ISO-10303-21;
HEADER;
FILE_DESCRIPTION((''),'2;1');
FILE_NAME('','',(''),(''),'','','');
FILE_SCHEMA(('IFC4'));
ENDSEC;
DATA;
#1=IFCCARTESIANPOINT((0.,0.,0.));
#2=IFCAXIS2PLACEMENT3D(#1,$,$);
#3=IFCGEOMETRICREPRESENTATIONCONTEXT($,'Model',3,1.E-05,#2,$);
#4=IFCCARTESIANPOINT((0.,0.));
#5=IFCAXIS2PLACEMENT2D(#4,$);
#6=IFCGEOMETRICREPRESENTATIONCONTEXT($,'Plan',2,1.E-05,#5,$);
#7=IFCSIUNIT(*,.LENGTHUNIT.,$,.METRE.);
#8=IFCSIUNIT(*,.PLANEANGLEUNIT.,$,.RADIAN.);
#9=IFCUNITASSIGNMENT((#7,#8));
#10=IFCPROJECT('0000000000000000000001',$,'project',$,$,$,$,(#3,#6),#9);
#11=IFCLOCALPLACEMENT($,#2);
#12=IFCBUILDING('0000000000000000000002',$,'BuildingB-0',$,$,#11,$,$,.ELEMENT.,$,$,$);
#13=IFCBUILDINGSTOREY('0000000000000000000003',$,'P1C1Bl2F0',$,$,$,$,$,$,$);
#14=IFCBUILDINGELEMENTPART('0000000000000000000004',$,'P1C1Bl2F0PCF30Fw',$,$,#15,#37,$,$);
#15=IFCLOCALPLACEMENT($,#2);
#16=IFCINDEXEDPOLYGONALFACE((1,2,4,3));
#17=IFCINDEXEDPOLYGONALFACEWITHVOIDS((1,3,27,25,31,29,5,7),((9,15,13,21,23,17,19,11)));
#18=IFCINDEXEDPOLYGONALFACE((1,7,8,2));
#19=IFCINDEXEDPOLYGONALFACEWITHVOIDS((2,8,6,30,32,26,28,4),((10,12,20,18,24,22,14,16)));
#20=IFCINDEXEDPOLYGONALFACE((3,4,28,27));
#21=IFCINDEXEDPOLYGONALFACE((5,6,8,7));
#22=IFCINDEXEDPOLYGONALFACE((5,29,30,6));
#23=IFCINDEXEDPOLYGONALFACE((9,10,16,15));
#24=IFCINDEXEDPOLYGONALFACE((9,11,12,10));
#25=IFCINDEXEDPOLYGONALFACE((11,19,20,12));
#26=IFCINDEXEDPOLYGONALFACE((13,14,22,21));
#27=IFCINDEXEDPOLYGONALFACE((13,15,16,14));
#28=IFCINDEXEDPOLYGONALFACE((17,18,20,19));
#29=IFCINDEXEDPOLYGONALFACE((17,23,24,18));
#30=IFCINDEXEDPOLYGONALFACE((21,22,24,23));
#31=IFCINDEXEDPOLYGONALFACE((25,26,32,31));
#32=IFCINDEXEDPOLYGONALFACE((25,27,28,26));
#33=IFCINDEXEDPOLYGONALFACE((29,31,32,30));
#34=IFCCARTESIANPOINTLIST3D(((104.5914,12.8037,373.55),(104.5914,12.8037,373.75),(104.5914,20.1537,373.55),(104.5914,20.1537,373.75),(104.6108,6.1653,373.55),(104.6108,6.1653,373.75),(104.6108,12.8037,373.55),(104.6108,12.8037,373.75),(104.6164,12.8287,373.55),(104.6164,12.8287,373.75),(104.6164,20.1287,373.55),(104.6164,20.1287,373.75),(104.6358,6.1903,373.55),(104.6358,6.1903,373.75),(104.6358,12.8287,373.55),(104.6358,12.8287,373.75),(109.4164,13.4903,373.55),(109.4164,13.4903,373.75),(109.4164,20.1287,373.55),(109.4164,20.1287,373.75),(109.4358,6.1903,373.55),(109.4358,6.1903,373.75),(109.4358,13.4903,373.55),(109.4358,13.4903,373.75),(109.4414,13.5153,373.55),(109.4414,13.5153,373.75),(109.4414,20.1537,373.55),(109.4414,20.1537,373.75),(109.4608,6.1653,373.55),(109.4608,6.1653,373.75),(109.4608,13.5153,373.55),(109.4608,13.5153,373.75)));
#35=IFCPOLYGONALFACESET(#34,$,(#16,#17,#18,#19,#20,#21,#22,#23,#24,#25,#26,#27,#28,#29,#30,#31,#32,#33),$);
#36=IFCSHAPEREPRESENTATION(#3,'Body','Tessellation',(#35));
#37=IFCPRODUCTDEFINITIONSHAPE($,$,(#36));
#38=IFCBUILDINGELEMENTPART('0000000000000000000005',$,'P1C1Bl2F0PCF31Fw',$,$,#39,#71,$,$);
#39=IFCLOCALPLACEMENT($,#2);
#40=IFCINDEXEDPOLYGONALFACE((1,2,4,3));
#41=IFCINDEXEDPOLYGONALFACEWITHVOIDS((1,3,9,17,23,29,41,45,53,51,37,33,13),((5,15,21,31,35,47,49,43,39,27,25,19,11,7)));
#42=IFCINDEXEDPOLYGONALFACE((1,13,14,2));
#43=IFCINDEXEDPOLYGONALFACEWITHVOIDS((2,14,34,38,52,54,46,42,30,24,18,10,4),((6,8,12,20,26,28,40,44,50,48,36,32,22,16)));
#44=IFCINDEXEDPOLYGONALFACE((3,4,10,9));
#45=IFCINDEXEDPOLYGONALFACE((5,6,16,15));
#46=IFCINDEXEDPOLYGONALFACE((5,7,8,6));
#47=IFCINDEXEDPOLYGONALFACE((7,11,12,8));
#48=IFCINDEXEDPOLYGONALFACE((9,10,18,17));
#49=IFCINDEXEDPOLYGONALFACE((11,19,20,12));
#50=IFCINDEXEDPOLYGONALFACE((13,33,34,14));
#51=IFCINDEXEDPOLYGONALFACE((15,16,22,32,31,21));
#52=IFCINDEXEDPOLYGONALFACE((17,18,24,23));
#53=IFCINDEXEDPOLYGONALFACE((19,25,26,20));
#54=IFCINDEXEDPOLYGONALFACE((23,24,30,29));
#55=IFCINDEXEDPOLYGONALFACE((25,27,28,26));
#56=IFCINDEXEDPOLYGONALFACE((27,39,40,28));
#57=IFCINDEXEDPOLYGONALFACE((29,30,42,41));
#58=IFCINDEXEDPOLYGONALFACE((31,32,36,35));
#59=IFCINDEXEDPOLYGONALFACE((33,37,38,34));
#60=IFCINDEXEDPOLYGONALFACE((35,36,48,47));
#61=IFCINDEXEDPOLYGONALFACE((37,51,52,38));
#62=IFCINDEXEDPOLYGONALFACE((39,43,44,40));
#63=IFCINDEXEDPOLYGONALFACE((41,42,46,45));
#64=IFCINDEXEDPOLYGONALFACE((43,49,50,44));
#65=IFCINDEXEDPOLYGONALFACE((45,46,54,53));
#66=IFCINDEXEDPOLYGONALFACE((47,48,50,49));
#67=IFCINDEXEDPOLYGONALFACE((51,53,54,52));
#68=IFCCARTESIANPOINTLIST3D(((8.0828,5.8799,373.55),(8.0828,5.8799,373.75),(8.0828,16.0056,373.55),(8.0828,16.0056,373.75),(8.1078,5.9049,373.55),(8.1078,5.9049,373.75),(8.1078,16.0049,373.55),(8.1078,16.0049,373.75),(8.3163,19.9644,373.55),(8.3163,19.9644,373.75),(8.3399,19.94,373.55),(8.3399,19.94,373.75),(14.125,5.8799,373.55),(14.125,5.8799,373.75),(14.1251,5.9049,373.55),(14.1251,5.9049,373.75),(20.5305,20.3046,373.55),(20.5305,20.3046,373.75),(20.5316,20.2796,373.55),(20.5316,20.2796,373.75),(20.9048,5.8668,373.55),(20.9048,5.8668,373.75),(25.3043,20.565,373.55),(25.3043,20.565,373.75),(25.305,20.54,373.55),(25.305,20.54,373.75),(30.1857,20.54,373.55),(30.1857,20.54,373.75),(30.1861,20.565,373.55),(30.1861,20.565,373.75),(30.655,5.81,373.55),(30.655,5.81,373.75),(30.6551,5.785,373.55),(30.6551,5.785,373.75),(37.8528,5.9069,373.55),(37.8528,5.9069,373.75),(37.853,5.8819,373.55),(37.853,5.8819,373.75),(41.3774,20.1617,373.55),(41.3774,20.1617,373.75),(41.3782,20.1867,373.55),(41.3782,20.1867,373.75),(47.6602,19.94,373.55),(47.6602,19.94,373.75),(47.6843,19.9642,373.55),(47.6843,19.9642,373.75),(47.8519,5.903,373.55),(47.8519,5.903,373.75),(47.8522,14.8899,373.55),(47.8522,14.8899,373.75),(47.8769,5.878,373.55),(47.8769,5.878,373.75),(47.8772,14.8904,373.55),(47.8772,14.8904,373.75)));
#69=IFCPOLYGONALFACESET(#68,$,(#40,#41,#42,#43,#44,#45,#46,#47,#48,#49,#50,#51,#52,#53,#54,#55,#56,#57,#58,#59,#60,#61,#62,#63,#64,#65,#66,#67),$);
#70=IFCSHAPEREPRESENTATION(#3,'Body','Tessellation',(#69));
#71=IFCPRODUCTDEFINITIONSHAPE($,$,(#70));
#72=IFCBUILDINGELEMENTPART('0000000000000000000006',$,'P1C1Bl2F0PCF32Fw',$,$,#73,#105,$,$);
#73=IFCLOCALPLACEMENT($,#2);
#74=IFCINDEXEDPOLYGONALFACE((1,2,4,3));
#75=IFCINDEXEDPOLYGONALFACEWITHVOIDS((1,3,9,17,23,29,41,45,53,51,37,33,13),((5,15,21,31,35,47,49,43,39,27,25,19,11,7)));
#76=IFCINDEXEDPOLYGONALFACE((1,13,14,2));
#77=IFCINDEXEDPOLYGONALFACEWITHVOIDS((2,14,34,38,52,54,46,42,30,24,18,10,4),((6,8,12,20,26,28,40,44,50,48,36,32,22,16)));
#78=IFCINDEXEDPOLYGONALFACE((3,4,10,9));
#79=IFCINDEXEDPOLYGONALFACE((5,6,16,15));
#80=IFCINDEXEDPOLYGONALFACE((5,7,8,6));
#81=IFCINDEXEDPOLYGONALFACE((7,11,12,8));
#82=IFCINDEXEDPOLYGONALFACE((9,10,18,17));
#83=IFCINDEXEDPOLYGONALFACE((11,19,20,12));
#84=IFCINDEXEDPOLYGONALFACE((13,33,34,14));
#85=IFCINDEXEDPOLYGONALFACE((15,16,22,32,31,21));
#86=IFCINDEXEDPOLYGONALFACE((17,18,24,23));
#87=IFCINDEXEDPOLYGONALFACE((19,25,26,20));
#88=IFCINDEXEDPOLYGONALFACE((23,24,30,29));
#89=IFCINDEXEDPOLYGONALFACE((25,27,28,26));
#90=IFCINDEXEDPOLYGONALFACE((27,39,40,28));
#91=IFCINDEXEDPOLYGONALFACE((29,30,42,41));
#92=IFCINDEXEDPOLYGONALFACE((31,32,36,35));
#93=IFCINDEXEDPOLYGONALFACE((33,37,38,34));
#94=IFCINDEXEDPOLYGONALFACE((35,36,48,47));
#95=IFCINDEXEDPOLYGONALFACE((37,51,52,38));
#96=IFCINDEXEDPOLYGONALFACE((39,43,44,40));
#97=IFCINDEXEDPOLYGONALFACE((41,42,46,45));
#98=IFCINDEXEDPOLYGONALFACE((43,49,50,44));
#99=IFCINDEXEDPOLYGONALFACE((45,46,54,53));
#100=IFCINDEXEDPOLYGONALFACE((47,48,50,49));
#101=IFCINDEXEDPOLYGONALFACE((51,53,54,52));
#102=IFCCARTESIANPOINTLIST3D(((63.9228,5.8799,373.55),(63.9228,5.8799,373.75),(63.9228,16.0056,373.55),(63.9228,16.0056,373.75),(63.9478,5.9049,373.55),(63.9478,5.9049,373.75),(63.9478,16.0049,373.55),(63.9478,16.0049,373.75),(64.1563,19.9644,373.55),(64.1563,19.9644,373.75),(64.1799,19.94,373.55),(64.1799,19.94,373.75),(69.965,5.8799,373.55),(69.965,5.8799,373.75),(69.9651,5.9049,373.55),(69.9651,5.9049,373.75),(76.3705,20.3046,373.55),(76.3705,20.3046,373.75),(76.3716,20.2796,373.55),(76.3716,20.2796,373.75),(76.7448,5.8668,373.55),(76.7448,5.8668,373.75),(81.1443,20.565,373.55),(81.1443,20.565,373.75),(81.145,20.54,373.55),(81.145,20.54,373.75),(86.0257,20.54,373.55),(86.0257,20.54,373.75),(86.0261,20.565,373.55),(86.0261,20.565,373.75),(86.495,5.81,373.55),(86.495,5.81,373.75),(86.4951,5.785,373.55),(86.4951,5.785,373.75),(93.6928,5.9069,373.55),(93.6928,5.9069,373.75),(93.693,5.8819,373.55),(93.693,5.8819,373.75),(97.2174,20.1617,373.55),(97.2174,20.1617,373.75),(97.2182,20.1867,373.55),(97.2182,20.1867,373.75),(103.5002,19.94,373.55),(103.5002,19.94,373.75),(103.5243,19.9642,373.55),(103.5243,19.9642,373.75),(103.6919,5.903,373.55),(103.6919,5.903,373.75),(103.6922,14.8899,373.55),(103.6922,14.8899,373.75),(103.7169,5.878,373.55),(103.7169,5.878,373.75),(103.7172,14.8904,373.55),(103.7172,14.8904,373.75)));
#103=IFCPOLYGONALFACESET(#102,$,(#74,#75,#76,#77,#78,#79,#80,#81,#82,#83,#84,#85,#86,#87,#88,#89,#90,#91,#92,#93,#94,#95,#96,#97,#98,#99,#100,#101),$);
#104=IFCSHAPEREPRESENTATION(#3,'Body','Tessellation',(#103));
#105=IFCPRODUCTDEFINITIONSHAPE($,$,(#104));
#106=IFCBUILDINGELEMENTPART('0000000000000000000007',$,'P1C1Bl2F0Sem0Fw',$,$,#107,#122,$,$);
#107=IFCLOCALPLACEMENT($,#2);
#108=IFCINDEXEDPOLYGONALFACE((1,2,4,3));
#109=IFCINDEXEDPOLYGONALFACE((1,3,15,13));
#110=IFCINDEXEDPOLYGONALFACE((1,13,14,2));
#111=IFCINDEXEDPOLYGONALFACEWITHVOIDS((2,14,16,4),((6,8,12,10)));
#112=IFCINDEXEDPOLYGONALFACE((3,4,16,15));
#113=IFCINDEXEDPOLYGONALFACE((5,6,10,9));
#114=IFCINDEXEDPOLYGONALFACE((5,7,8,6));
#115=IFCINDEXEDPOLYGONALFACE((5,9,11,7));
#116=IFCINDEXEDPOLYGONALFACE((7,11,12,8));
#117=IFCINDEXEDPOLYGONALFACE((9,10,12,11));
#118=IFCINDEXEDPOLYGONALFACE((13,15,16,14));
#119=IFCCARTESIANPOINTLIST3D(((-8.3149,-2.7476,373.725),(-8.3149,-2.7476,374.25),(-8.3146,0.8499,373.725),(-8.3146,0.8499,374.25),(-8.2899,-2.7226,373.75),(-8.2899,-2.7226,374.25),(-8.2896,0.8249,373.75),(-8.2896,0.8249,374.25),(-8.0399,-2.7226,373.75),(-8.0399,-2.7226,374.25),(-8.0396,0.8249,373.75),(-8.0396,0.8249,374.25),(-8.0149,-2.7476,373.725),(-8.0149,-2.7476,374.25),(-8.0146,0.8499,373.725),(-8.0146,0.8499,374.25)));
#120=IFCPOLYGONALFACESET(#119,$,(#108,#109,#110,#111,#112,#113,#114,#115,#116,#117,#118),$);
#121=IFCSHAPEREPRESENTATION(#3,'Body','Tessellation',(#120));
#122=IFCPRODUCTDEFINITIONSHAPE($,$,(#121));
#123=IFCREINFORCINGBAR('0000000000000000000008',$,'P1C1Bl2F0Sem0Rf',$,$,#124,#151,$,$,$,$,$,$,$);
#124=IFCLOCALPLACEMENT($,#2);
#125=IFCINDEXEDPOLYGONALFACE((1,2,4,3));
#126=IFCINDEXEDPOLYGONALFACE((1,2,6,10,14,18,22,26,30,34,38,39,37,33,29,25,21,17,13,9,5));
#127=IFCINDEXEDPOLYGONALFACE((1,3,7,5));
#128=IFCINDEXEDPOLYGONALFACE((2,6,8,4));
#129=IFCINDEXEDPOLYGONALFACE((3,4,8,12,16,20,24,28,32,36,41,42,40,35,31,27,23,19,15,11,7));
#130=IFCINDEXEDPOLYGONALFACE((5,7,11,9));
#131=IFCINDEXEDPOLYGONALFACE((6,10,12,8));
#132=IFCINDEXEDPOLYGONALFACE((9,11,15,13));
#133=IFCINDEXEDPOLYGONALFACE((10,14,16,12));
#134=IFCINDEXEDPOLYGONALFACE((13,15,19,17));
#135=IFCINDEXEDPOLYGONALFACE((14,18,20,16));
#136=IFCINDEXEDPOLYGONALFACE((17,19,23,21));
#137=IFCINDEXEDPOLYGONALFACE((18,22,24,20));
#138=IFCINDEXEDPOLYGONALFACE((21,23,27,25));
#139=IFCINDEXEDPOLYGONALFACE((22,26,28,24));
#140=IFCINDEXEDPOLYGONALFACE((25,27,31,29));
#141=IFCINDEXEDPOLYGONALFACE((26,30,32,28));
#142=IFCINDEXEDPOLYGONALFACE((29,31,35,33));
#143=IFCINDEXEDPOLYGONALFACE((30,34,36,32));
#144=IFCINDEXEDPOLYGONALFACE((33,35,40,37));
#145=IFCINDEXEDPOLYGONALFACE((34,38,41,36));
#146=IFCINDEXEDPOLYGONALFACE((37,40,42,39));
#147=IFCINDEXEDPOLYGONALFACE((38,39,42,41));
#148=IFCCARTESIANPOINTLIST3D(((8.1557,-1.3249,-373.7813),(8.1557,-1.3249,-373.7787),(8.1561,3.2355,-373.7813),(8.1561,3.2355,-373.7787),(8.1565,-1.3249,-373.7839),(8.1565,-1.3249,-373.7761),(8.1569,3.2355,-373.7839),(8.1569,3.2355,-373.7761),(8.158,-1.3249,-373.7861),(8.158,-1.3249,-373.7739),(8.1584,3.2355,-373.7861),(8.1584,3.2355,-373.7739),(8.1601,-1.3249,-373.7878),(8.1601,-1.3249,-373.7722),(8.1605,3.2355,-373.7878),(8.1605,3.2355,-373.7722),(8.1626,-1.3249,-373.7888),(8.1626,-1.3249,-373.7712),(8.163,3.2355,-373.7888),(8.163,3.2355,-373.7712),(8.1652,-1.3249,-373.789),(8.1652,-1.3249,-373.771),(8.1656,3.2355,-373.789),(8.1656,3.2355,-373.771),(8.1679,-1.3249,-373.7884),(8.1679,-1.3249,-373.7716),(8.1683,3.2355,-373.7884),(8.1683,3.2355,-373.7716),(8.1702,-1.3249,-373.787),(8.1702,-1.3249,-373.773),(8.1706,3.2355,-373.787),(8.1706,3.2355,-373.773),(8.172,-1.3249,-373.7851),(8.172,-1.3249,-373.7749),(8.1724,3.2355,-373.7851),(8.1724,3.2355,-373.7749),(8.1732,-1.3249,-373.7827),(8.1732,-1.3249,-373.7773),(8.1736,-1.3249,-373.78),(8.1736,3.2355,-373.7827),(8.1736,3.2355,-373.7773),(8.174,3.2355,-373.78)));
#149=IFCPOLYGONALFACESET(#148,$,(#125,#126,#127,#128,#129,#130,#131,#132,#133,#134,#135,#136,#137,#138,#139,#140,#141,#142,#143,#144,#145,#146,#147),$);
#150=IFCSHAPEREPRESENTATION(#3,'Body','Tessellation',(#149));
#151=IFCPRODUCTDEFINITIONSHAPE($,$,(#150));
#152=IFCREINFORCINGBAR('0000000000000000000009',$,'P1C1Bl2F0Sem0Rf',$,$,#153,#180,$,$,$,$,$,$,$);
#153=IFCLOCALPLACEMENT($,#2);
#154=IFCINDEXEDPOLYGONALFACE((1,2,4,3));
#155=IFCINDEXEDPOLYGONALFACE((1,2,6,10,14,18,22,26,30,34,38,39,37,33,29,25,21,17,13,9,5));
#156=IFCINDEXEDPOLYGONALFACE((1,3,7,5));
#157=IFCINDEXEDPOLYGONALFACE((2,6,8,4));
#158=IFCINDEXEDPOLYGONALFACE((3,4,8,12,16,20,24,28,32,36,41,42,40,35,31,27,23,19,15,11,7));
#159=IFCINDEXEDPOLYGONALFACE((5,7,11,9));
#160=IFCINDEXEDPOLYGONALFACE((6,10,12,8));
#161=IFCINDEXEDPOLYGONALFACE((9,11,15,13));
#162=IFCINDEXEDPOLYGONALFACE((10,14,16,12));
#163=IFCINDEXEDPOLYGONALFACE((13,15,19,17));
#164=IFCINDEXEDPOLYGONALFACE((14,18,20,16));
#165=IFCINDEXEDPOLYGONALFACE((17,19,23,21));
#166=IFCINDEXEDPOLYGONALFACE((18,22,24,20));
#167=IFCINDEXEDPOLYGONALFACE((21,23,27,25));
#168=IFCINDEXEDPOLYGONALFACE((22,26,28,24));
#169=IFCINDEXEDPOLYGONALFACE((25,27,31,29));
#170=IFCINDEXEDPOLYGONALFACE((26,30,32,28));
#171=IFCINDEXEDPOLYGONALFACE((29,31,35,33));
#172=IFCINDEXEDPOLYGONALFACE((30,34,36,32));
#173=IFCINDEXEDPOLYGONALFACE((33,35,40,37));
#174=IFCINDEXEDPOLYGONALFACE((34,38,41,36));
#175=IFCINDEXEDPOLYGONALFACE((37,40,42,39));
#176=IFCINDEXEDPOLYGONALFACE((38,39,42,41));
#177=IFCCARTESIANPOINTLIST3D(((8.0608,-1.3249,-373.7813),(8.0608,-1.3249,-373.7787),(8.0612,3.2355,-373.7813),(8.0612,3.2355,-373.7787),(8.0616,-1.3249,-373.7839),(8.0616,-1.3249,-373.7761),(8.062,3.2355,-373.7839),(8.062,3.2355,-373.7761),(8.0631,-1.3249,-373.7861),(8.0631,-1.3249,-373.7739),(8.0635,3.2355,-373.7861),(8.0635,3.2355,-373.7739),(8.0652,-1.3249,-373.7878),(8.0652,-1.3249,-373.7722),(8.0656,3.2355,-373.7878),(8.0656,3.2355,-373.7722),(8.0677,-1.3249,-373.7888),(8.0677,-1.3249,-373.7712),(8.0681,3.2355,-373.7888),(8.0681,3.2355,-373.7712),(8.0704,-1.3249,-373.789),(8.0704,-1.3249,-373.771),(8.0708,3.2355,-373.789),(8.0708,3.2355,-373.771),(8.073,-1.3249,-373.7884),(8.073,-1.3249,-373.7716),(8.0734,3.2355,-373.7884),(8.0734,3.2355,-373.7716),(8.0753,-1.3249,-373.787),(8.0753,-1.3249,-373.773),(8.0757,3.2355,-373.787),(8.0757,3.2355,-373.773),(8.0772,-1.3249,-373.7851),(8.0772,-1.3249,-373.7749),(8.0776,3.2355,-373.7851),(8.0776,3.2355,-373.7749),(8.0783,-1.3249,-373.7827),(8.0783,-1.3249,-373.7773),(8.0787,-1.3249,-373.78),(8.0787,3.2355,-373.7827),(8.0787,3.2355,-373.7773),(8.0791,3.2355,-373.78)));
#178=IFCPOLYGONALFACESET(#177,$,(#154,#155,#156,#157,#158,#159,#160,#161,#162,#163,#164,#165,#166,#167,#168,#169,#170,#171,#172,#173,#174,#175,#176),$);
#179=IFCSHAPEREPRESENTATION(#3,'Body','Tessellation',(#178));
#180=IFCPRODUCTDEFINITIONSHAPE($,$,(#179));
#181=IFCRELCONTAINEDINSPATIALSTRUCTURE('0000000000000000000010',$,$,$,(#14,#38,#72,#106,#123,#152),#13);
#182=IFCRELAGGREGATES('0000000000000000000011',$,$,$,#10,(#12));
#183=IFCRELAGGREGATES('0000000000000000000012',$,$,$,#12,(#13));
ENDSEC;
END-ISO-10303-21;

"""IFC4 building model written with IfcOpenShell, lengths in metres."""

from ifc_helpers import new_model, entity, si_unit, origin, origin_2d, place, context, project, spatial, polyline, outline, extrude, element, save


model = new_model("IFC4")

# Units and contexts
model_context = context("Model", 3, precision=1e-05, world=origin())
plan_context = context("Plan", 2, precision=1e-05, world=origin_2d())
ifc_project = project(units=[si_unit("LENGTHUNIT", "METRE"), si_unit("PLANEANGLEUNIT", "RADIAN")], contexts=[model_context, plan_context])

# Building, storey
building_placement = place(None, origin())
building = spatial("IfcBuilding", under=ifc_project, at=building_placement, Name="BuildingB-0", CompositionType="ELEMENT")
storey = spatial("IfcBuildingStorey", under=building, Name="P1C1Bl2F0")

# Building element parts, openings
building_element_part_1 = element("IfcBuildingElementPart", 1, inside=storey, Name="P1C1Bl2F0PCF30Fw", context=model_context, shape_type="SweptSolid", body=[
    extrude(outline(polyline([(104.6108, 12.8037, 373.55), (104.5914, 12.8037, 373.55), (104.5914, 15.1899, 373.55), (104.5914, 20.1537, 373.55), (109.4414, 20.1537, 373.55), (109.4414, 17.04, 373.55), (109.4414, 13.5153, 373.55), (109.4608, 13.5153, 373.55), (109.4608, 9.16, 373.55), (109.4608, 6.1653, 373.55), (106.4755, 6.1653, 373.55), (104.6108, 6.1653, 373.55), (104.6108, 9.3099, 373.55), (104.6108, 12.8037, 373.55)])), None, (0.0, 0.0, 1.0), 0.2),
])
element("IfcOpeningElement", 2, inside=storey, cuts=building_element_part_1, context=model_context, shape_type="SweptSolid", body=[
    extrude(outline(polyline([(104.6358, 12.8287, 373.55), (104.6164, 12.8287, 373.55), (104.6164, 15.1899, 373.55), (104.6164, 20.1287, 373.55), (109.4164, 20.1287, 373.55), (109.4164, 17.04, 373.55), (109.4164, 13.4903, 373.55), (109.4358, 13.4903, 373.55), (109.4358, 9.16, 373.55), (109.4358, 6.1903, 373.55), (106.4755, 6.1903, 373.55), (104.6358, 6.1903, 373.55), (104.6358, 9.3099, 373.55), (104.6358, 12.8287, 373.55)])), None, (0.0, 0.0, 1.0), 0.2),
])
building_element_part_2 = element("IfcBuildingElementPart", 3, inside=storey, Name="P1C1Bl2F0PCF31Fw", context=model_context, shape_type="SweptSolid", body=[
    extrude(outline(polyline([(8.3163, 19.9644, 373.55), (20.5305, 20.3046, 373.55), (25.3043, 20.565, 373.55), (30.1861, 20.565, 373.55), (41.3782, 20.1867, 373.55), (47.6843, 19.9642, 373.55), (47.8772, 14.8904, 373.55), (47.8769, 5.878, 373.55), (37.853, 5.8819, 373.55), (30.6551, 5.785, 373.55), (20.9046, 5.8418, 373.55), (14.125, 5.8799, 373.55), (8.0828, 5.8799, 373.55), (8.0828, 16.0056, 373.55), (8.3163, 19.9644, 373.55)])), None, (0.0, 0.0, 1.0), 0.2),
])
element("IfcOpeningElement", 4, inside=storey, cuts=building_element_part_2, context=model_context, shape_type="SweptSolid", body=[
    extrude(outline(polyline([(8.3399, 19.94, 373.55), (20.5316, 20.2796, 373.55), (25.305, 20.54, 373.55), (30.1857, 20.54, 373.55), (41.3774, 20.1617, 373.55), (47.6602, 19.94, 373.55), (47.8522, 14.8899, 373.55), (47.8519, 5.903, 373.55), (37.8528, 5.9069, 373.55), (30.655, 5.81, 373.55), (20.9048, 5.8668, 373.55), (14.1251, 5.9049, 373.55), (8.1078, 5.9049, 373.55), (8.1078, 16.0049, 373.55), (8.3399, 19.94, 373.55)])), None, (0.0, 0.0, 1.0), 0.2),
])
building_element_part_3 = element("IfcBuildingElementPart", 5, inside=storey, Name="P1C1Bl2F0PCF32Fw", context=model_context, shape_type="SweptSolid", body=[
    extrude(outline(polyline([(64.1563, 19.9644, 373.55), (76.3705, 20.3046, 373.55), (81.1443, 20.565, 373.55), (86.0261, 20.565, 373.55), (97.2182, 20.1867, 373.55), (103.5243, 19.9642, 373.55), (103.7172, 14.8904, 373.55), (103.7169, 5.878, 373.55), (93.693, 5.8819, 373.55), (86.4951, 5.785, 373.55), (76.7446, 5.8418, 373.55), (69.965, 5.8799, 373.55), (63.9228, 5.8799, 373.55), (63.9228, 16.0056, 373.55), (64.1563, 19.9644, 373.55)])), None, (0.0, 0.0, 1.0), 0.2),
])
element("IfcOpeningElement", 6, inside=storey, cuts=building_element_part_3, context=model_context, shape_type="SweptSolid", body=[
    extrude(outline(polyline([(64.1799, 19.94, 373.55), (76.3716, 20.2796, 373.55), (81.145, 20.54, 373.55), (86.0257, 20.54, 373.55), (97.2174, 20.1617, 373.55), (103.5002, 19.94, 373.55), (103.6922, 14.8899, 373.55), (103.6919, 5.903, 373.55), (93.6928, 5.9069, 373.55), (86.495, 5.81, 373.55), (76.7448, 5.8668, 373.55), (69.9651, 5.9049, 373.55), (63.9478, 5.9049, 373.55), (63.9478, 16.0049, 373.55), (64.1799, 19.94, 373.55)])), None, (0.0, 0.0, 1.0), 0.2),
])
building_element_part_4 = element("IfcBuildingElementPart", 7, inside=storey, Name="P1C1Bl2F0Sem0Fw", context=model_context, shape_type="SweptSolid", body=[
    extrude(outline(polyline([(-8.3149, -2.7476, 373.725), (-8.0149, -2.7476, 373.725), (-8.0146, 0.8499, 373.725), (-8.3146, 0.8499, 373.725), (-8.3149, -2.7476, 373.725)])), None, (0.0, 0.0, 1.0), 0.525),
])
element("IfcOpeningElement", 8, inside=storey, cuts=building_element_part_4, context=model_context, shape_type="SweptSolid", body=[
    extrude(outline(polyline([(-8.2899, -2.7226, 373.75), (-8.0399, -2.7226, 373.75), (-8.0396, 0.8249, 373.75), (-8.2896, 0.8249, 373.75), (-8.2899, -2.7226, 373.75)])), None, (0.0, 0.0, 1.0), 0.5),
])

# Reinforcing bars
element("IfcReinforcingBar", 9, inside=storey, Name="P1C1Bl2F0Sem0Rf", context=model_context, shape_type="SweptSolid", body=[
    entity("IfcSurfaceCurveSweptAreaSolid", entity("IfcCircleProfileDef", "AREA", None, None, 0.009), None, entity("IfcPolyline", [entity("IfcCartesianPoint", [-8.165, -3.2355, 373.78]), entity("IfcCartesianPoint", [-8.1646, 1.3249, 373.78])]), None, None, entity("IfcPlane", entity("IfcAxis2Placement3D", entity("IfcCartesianPoint", [-8.165, -3.2355, 373.78]), entity("IfcDirection", [0.0, 0.0, 1.0]), entity("IfcDirection", [1.0, 0.0, 0.0])))),
])
element("IfcReinforcingBar", 10, inside=storey, Name="P1C1Bl2F0Sem0Rf", context=model_context, shape_type="SweptSolid", body=[
    entity("IfcSurfaceCurveSweptAreaSolid", entity("IfcCircleProfileDef", "AREA", None, None, 0.009), None, entity("IfcPolyline", [entity("IfcCartesianPoint", [-8.0701, -3.2355, 373.78]), entity("IfcCartesianPoint", [-8.0697, 1.3249, 373.78])]), None, None, entity("IfcPlane", entity("IfcAxis2Placement3D", entity("IfcCartesianPoint", [-8.0701, -3.2355, 373.78]), entity("IfcDirection", [0.0, 0.0, 1.0]), entity("IfcDirection", [1.0, 0.0, 0.0])))),
])

save(model, "model.ifc")
